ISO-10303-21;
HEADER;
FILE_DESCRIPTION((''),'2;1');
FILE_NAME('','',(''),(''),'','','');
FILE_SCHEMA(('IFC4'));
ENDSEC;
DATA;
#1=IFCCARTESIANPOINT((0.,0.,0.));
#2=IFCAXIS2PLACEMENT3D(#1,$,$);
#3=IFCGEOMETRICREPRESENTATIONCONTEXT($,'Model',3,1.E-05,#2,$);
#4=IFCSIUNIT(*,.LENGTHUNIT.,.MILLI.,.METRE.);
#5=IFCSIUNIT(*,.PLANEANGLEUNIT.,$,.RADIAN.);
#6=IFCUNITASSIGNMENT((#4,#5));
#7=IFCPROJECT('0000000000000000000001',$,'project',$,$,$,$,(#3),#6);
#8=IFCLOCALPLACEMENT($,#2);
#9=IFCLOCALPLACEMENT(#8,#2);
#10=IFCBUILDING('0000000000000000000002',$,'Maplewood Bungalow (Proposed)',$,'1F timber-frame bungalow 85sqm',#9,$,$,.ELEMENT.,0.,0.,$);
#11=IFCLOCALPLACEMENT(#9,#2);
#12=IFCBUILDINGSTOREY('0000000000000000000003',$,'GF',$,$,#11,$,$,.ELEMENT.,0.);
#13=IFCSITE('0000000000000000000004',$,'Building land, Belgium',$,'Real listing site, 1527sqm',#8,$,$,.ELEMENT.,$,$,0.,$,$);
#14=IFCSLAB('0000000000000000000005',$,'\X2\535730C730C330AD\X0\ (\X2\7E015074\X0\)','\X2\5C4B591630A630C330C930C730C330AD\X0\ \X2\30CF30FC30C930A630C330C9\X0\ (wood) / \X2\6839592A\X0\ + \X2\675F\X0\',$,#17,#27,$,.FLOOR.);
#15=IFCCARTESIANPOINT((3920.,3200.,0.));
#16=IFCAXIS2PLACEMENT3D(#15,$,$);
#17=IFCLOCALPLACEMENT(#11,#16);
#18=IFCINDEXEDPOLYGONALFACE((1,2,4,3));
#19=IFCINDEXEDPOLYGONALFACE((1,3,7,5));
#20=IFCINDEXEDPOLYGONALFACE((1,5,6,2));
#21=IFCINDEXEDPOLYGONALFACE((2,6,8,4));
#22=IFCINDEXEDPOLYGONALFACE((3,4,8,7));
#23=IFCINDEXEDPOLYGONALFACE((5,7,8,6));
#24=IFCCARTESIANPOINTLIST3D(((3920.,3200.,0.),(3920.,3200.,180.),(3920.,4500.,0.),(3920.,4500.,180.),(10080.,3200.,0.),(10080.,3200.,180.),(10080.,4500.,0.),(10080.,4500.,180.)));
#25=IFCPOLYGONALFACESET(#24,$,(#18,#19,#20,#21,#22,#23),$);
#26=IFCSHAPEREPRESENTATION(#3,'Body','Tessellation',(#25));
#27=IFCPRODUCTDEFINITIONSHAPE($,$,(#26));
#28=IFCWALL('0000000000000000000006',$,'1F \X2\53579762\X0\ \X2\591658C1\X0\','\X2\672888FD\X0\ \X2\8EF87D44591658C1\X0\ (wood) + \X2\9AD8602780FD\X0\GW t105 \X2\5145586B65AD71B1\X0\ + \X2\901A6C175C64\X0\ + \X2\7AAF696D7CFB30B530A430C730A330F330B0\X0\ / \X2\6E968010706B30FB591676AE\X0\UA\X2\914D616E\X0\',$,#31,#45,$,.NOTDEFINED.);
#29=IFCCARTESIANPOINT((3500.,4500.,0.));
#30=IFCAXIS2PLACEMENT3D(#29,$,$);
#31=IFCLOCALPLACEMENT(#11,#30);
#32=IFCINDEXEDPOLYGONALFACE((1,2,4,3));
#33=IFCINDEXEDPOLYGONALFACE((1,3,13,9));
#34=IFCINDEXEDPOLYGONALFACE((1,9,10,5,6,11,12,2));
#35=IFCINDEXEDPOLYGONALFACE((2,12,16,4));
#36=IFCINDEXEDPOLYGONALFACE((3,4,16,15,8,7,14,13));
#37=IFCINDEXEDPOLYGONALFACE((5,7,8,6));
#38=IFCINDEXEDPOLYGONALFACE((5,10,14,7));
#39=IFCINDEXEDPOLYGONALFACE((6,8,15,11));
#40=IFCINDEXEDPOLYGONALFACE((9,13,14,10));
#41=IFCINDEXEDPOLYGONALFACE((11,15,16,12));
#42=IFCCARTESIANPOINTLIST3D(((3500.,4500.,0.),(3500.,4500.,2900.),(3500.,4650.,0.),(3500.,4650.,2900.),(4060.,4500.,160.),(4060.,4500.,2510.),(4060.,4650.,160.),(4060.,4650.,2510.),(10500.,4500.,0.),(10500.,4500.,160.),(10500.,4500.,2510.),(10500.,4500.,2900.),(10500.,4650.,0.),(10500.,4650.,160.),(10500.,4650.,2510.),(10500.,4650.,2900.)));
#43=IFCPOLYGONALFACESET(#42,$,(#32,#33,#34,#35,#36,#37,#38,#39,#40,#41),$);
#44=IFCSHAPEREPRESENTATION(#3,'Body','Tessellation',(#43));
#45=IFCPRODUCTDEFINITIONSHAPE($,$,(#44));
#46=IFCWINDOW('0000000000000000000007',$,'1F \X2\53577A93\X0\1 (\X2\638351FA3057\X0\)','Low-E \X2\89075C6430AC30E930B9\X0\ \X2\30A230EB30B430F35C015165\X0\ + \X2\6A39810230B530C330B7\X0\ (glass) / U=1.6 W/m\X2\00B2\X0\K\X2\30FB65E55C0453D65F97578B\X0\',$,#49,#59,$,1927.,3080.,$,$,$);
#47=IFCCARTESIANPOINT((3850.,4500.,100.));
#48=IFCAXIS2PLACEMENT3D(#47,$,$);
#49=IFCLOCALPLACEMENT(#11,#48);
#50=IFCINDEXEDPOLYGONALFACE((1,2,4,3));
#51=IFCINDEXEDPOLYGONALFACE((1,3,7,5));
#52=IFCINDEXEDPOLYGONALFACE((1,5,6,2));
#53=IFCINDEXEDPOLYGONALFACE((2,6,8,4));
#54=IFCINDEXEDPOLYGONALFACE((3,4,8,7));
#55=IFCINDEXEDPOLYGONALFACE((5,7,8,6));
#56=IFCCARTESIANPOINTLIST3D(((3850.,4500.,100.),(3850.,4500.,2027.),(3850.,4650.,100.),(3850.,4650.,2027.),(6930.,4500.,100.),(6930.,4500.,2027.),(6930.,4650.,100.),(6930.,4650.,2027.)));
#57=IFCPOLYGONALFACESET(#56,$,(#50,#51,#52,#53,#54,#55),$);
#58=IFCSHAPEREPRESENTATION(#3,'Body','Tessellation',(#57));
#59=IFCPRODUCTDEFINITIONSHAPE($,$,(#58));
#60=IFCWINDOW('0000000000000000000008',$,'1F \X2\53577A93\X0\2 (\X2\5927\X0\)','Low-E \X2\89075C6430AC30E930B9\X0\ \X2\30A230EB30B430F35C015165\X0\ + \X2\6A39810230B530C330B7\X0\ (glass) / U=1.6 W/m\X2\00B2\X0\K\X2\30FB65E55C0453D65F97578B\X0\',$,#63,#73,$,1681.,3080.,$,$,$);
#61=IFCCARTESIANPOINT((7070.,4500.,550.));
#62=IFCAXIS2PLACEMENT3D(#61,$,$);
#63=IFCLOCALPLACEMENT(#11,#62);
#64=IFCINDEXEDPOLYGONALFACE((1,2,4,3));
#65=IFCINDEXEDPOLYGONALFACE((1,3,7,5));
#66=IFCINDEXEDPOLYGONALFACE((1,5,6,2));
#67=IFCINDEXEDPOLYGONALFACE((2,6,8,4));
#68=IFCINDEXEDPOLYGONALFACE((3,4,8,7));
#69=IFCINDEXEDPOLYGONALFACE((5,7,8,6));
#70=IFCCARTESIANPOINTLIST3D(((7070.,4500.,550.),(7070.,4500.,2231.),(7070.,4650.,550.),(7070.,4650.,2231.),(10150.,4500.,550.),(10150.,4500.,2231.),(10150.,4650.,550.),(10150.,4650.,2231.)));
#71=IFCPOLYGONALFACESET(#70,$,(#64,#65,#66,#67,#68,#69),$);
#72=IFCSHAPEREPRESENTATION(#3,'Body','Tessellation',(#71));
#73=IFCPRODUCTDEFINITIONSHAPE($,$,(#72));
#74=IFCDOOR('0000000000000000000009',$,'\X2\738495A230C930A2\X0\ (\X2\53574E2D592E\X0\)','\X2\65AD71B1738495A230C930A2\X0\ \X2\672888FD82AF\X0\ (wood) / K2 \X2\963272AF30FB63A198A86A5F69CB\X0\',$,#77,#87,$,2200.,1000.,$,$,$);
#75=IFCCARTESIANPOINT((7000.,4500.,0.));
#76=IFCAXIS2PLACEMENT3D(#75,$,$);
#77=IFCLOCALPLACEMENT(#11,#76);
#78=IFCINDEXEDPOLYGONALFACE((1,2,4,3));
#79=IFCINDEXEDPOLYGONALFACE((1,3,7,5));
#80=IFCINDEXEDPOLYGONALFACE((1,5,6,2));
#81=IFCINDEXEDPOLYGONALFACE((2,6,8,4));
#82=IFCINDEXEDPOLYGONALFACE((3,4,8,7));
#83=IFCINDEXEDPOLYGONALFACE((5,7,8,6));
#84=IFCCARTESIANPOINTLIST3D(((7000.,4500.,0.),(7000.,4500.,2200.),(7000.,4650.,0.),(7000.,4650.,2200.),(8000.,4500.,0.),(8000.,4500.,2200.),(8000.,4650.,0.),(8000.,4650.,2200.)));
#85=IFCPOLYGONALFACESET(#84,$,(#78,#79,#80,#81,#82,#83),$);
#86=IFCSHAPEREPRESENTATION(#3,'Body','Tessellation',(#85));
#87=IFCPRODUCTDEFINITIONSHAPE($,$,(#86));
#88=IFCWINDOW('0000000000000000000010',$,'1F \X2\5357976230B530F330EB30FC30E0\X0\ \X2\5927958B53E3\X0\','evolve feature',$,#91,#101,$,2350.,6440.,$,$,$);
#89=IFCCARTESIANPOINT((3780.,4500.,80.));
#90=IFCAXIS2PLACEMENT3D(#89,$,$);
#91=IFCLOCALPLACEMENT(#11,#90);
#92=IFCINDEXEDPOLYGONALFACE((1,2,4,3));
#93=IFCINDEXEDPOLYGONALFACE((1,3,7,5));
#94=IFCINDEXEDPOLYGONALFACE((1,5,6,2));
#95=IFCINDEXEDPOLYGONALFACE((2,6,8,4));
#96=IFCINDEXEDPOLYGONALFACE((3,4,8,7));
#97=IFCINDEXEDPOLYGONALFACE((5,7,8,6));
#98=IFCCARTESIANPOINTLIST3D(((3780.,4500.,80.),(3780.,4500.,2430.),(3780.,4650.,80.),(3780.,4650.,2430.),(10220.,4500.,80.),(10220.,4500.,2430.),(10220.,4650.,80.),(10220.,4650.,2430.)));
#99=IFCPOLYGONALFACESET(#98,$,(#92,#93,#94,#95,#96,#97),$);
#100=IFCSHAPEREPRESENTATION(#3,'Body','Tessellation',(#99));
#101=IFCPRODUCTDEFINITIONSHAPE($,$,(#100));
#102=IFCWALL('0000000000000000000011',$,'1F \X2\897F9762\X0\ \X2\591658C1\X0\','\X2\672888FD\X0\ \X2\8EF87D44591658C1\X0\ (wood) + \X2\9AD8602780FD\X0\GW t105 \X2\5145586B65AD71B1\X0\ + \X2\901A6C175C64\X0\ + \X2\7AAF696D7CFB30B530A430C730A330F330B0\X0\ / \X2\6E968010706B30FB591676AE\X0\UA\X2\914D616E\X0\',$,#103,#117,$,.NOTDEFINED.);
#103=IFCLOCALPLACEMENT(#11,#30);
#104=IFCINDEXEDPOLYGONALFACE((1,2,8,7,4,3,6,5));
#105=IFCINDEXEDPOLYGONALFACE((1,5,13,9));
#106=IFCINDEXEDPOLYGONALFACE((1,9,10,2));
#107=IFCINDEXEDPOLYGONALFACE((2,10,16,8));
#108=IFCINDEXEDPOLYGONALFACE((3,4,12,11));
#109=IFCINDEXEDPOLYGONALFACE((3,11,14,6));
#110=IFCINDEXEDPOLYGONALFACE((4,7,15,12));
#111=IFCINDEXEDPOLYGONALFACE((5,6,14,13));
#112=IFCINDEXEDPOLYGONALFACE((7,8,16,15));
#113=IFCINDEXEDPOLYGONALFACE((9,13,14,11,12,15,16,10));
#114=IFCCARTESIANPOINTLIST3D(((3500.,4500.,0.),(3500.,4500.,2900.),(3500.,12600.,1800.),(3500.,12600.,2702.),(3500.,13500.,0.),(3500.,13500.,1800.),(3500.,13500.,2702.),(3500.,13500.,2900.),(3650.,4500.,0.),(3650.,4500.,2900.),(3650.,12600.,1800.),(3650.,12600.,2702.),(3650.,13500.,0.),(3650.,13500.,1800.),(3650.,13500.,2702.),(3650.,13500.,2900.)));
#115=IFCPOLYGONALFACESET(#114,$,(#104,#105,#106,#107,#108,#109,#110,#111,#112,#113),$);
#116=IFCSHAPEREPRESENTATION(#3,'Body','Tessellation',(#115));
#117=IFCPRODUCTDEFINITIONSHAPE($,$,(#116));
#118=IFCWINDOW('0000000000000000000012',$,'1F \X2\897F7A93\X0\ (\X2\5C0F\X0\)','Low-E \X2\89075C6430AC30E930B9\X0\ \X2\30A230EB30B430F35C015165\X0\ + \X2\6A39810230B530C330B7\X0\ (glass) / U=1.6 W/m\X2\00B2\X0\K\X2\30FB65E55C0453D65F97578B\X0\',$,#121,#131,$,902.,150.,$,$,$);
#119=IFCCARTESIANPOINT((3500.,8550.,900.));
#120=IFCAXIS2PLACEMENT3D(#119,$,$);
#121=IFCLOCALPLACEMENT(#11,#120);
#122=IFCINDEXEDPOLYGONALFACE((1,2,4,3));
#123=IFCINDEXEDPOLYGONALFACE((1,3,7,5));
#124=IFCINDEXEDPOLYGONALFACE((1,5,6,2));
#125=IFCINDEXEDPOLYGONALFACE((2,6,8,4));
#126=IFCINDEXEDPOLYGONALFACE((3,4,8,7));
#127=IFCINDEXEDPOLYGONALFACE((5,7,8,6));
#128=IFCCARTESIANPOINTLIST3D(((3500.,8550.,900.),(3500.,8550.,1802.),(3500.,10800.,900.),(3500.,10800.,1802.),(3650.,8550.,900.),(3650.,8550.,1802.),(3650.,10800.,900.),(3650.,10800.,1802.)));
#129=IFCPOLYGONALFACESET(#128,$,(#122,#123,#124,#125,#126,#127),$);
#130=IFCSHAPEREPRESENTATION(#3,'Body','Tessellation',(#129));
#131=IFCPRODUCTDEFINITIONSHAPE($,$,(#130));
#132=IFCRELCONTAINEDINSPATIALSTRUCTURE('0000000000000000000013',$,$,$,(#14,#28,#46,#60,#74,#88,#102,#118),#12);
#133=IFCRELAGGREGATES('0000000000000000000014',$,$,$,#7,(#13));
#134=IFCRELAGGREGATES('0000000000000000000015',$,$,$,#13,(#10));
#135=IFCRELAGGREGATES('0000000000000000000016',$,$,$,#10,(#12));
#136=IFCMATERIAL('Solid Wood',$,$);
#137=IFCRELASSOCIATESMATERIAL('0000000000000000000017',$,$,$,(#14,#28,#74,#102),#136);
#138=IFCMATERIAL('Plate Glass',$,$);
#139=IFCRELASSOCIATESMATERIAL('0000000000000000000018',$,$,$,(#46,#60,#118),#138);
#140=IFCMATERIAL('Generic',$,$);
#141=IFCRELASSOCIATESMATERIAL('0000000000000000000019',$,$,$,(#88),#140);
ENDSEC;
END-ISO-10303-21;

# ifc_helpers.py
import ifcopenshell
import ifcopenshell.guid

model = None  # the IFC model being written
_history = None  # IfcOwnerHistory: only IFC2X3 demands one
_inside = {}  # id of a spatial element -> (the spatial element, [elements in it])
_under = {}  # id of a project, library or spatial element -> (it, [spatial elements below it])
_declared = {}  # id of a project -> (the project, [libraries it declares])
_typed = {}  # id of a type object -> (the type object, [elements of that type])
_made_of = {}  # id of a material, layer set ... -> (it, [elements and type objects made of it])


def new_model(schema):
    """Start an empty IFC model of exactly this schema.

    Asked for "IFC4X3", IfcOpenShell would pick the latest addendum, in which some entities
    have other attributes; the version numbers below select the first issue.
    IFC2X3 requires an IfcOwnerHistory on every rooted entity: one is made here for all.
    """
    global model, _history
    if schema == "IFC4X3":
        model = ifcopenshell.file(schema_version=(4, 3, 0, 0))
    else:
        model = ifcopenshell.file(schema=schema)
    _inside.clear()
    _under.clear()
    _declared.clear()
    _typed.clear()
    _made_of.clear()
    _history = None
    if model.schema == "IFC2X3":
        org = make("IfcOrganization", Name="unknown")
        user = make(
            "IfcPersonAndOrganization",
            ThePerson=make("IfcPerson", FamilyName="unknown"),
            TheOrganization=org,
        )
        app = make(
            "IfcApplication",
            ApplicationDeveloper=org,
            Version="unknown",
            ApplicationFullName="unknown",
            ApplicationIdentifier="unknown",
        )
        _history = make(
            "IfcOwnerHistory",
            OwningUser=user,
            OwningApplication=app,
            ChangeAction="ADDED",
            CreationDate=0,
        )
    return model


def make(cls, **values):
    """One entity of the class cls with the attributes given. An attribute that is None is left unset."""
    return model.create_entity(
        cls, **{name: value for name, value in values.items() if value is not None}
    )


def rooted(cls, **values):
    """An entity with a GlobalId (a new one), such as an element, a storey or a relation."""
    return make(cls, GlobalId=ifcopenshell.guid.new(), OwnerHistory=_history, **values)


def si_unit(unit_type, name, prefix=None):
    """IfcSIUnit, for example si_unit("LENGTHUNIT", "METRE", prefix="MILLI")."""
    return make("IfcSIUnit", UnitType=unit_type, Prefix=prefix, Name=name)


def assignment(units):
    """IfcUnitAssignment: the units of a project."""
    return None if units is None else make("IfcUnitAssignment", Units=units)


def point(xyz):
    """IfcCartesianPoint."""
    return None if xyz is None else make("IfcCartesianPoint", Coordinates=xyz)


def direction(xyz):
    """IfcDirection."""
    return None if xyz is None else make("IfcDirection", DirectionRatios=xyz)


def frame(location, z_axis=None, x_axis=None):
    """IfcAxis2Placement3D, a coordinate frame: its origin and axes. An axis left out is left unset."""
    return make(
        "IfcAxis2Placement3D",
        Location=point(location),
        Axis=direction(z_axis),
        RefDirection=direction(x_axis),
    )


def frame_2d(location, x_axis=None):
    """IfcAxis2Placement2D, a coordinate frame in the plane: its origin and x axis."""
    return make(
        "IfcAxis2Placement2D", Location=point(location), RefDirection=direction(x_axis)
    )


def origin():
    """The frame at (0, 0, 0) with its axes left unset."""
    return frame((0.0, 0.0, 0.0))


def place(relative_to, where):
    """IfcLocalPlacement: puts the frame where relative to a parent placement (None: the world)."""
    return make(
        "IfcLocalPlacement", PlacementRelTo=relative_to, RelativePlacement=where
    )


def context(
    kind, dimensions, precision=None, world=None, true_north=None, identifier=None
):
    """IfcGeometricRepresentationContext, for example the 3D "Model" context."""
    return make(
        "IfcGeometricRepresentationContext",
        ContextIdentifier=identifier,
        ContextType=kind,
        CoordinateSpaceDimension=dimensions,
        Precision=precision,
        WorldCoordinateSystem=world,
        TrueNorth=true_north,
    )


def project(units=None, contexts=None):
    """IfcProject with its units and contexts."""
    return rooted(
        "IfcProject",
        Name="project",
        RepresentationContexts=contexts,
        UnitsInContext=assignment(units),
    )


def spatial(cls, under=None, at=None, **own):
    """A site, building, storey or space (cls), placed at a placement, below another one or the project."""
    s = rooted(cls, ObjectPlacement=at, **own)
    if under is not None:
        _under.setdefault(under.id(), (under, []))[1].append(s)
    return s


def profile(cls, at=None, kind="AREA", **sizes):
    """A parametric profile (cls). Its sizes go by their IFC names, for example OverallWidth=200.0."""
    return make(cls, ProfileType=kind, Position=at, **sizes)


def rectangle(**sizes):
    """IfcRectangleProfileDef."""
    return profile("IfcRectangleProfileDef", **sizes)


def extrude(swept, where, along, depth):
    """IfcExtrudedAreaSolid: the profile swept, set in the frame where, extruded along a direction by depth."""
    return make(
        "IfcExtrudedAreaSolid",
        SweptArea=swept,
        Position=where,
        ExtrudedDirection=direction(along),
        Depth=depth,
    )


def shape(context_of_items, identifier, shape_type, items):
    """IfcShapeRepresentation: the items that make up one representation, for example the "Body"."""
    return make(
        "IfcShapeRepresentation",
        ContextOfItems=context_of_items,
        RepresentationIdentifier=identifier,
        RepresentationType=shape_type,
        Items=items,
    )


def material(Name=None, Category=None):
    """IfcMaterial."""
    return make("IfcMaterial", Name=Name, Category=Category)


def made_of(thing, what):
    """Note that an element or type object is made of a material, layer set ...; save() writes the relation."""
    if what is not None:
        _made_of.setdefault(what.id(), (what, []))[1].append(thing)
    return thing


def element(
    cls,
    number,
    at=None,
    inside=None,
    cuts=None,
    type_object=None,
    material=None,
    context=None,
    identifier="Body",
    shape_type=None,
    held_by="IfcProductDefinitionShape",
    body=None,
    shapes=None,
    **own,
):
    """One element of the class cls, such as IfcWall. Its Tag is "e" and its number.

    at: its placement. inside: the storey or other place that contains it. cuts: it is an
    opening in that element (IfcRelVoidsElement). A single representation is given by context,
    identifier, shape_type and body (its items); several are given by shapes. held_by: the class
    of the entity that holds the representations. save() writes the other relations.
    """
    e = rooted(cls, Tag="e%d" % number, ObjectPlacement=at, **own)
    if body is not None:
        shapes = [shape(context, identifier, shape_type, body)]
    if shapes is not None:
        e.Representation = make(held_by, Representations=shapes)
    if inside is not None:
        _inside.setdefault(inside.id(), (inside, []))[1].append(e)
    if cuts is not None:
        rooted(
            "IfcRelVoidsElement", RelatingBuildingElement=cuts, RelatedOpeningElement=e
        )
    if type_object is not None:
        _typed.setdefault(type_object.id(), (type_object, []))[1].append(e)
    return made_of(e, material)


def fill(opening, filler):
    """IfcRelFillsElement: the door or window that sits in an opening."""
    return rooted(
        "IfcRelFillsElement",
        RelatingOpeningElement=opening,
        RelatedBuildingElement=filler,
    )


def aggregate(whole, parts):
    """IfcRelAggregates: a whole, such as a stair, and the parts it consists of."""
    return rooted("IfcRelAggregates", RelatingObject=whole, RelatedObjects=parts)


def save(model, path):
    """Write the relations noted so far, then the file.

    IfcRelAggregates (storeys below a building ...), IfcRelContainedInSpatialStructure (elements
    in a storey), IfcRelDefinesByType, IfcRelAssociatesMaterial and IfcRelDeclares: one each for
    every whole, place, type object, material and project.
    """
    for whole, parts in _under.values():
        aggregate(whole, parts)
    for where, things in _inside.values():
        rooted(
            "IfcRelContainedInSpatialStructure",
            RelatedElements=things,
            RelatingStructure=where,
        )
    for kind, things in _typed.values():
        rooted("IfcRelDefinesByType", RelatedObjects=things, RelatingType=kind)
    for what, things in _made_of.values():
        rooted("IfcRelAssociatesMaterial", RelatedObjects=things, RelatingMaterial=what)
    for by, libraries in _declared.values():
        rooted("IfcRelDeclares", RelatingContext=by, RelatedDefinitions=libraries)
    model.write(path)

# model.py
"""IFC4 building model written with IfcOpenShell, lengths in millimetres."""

from ifc_helpers import new_model, si_unit, frame, frame_2d, origin, place, context, project, spatial, rectangle, extrude, material, element, fill, save


model = new_model("IFC4")

# Units and contexts
model_context = context("Model", 3, precision=1e-05, world=origin())
ifc_project = project(units=[si_unit("LENGTHUNIT", "METRE", prefix="MILLI"), si_unit("PLANEANGLEUNIT", "RADIAN")], contexts=[model_context])

# Site, building, storey
site_placement = place(None, origin())
site = spatial("IfcSite", under=ifc_project, at=site_placement, Name="Building land, Belgium", ObjectType="Real listing site, 1527sqm", CompositionType="ELEMENT", RefElevation=0.0)
building_placement = place(site_placement, origin())
building = spatial("IfcBuilding", under=site, at=building_placement, Name="Maplewood Bungalow (Proposed)", ObjectType="1F timber-frame bungalow 85sqm", CompositionType="ELEMENT", ElevationOfRefHeight=0.0, ElevationOfTerrain=0.0)
storey_placement = place(building_placement, origin())
storey = spatial("IfcBuildingStorey", under=building, at=storey_placement, Name="GF", CompositionType="ELEMENT", Elevation=0.0)

# Slab
ifc_material_1 = material(Name="Solid Wood")
slab_1_placement = place(storey_placement, frame((3920.0, 3200.0, 0.0)))
element("IfcSlab", 1, at=slab_1_placement, inside=storey, material=ifc_material_1, Name="南デッキ (縁側)", Description="屋外ウッドデッキ ハードウッド (wood) / 根太 + 束", PredefinedType="FLOOR", context=model_context, shape_type="SweptSolid", body=[
    extrude(rectangle(XDim=6160.0, YDim=1300.0, at=frame_2d((3080.0, 650.0))), frame((3920.0, 3200.0, 0.0)), (0.0, 0.0, 1.0), 180.0),
])
ifc_material_2 = material(Name="Generic")

# Wall, openings, windows, door
wall_1_placement = place(storey_placement, frame((3500.0, 4500.0, 0.0)))
wall_1 = element("IfcWall", 2, at=wall_1_placement, inside=storey, material=ifc_material_1, Name="1F 南面 外壁", Description="木製 軸組外壁 (wood) + 高性能GW t105 充填断熱 + 通気層 + 窯業系サイディング / 準耐火・外皮UA配慮", PredefinedType="NOTDEFINED", context=model_context, shape_type="SweptSolid", body=[
    extrude(rectangle(XDim=7000.0, YDim=150.0, at=frame_2d((3500.0, 75.0))), frame((3500.0, 4500.0, 0.0)), (0.0, 0.0, 1.0), 2900.0),
])
opening_1_placement = place(storey_placement, frame((3850.0, 4500.0, 100.0)))
opening_1 = element("IfcOpeningElement", 3, at=opening_1_placement, cuts=wall_1, PredefinedType="NOTDEFINED", context=model_context, shape_type="SweptSolid", body=[
    extrude(rectangle(XDim=3080.0, YDim=150.0, at=frame_2d((1540.0, 75.0))), frame((3850.0, 4500.0, 100.0)), (0.0, 0.0, 1.0), 1927.0),
])
opening_2_placement = place(storey_placement, frame((7070.0, 4500.0, 550.0)))
opening_2 = element("IfcOpeningElement", 4, at=opening_2_placement, cuts=wall_1, PredefinedType="NOTDEFINED", context=model_context, shape_type="SweptSolid", body=[
    extrude(rectangle(XDim=3080.0, YDim=150.0, at=frame_2d((1540.0, 75.0))), frame((7070.0, 4500.0, 550.0)), (0.0, 0.0, 1.0), 1681.0),
])
opening_3_placement = place(storey_placement, frame((7000.0, 4500.0, 0.0)))
opening_3 = element("IfcOpeningElement", 5, at=opening_3_placement, cuts=wall_1, PredefinedType="NOTDEFINED", context=model_context, shape_type="SweptSolid", body=[
    extrude(rectangle(XDim=1000.0, YDim=150.0, at=frame_2d((500.0, 75.0))), frame((7000.0, 4500.0, 0.0)), (0.0, 0.0, 1.0), 2200.0),
])
opening_4_placement = place(storey_placement, frame((3780.0, 4500.0, 80.0)))
opening_4 = element("IfcOpeningElement", 6, at=opening_4_placement, cuts=wall_1, PredefinedType="NOTDEFINED", context=model_context, shape_type="SweptSolid", body=[
    extrude(rectangle(XDim=6440.0, YDim=150.0, at=frame_2d((3220.0, 75.0))), frame((3780.0, 4500.0, 80.0)), (0.0, 0.0, 1.0), 2350.0),
])
ifc_material_3 = material(Name="Plate Glass")
window_1_placement = place(storey_placement, frame((3850.0, 4500.0, 100.0)))
window_1 = element("IfcWindow", 7, at=window_1_placement, inside=storey, material=ifc_material_3, Name="1F 南窓1 (掃出し)", Description="Low-E 複層ガラス アルゴン封入 + 樹脂サッシ (glass) / U=1.6 W/m²K・日射取得型", OverallHeight=1927.0, OverallWidth=3080.0, context=model_context, shape_type="SweptSolid", body=[
    extrude(rectangle(XDim=3080.0, YDim=150.0, at=frame_2d((1540.0, 75.0))), frame((3850.0, 4500.0, 100.0)), (0.0, 0.0, 1.0), 1927.0),
])
fill(opening_1, window_1)
window_2_placement = place(storey_placement, frame((7070.0, 4500.0, 550.0)))
window_2 = element("IfcWindow", 8, at=window_2_placement, inside=storey, material=ifc_material_3, Name="1F 南窓2 (大)", Description="Low-E 複層ガラス アルゴン封入 + 樹脂サッシ (glass) / U=1.6 W/m²K・日射取得型", OverallHeight=1681.0, OverallWidth=3080.0, context=model_context, shape_type="SweptSolid", body=[
    extrude(rectangle(XDim=3080.0, YDim=150.0, at=frame_2d((1540.0, 75.0))), frame((7070.0, 4500.0, 550.0)), (0.0, 0.0, 1.0), 1681.0),
])
fill(opening_2, window_2)
door_placement = place(storey_placement, frame((7000.0, 4500.0, 0.0)))
door = element("IfcDoor", 9, at=door_placement, inside=storey, material=ifc_material_1, Name="玄関ドア (南中央)", Description="断熱玄関ドア 木製芯 (wood) / K2 防犯・採風機構", OverallHeight=2200.0, OverallWidth=1000.0, context=model_context, shape_type="SweptSolid", body=[
    extrude(rectangle(XDim=1000.0, YDim=150.0, at=frame_2d((500.0, 75.0))), frame((7000.0, 4500.0, 0.0)), (0.0, 0.0, 1.0), 2200.0),
])
fill(opening_3, door)
window_3_placement = place(storey_placement, frame((3780.0, 4500.0, 80.0)))
window_3 = element("IfcWindow", 10, at=window_3_placement, inside=storey, material=ifc_material_2, Name="1F 南面サンルーム 大開口", Description="evolve feature", OverallHeight=2350.0, OverallWidth=6440.0, context=model_context, shape_type="SweptSolid", body=[
    extrude(rectangle(XDim=6440.0, YDim=150.0, at=frame_2d((3220.0, 75.0))), frame((3780.0, 4500.0, 80.0)), (0.0, 0.0, 1.0), 2350.0),
])
fill(opening_4, window_3)

# Wall, opening, window
wall_2_placement = place(storey_placement, frame((3500.0, 4500.0, 0.0)))
wall_2 = element("IfcWall", 11, at=wall_2_placement, inside=storey, material=ifc_material_1, Name="1F 西面 外壁", Description="木製 軸組外壁 (wood) + 高性能GW t105 充填断熱 + 通気層 + 窯業系サイディング / 準耐火・外皮UA配慮", PredefinedType="NOTDEFINED", context=model_context, shape_type="SweptSolid", body=[
    extrude(rectangle(XDim=150.0, YDim=9000.0, at=frame_2d((75.0, 4500.0))), frame((3500.0, 4500.0, 0.0)), (0.0, 0.0, 1.0), 2900.0),
])
opening_5_placement = place(storey_placement, frame((3500.0, 8550.0, 900.0)))
opening_5 = element("IfcOpeningElement", 12, at=opening_5_placement, cuts=wall_2, PredefinedType="NOTDEFINED", context=model_context, shape_type="SweptSolid", body=[
    extrude(rectangle(XDim=150.0, YDim=2250.0, at=frame_2d((75.0, 1125.0))), frame((3500.0, 8550.0, 900.0)), (0.0, 0.0, 1.0), 902.0),
])
window_4_placement = place(storey_placement, frame((3500.0, 8550.0, 900.0)))
window_4 = element("IfcWindow", 13, at=window_4_placement, inside=storey, material=ifc_material_3, Name="1F 西窓 (小)", Description="Low-E 複層ガラス アルゴン封入 + 樹脂サッシ (glass) / U=1.6 W/m²K・日射取得型", OverallHeight=902.0, OverallWidth=150.0, context=model_context, shape_type="SweptSolid", body=[
    extrude(rectangle(XDim=150.0, YDim=2250.0, at=frame_2d((75.0, 1125.0))), frame((3500.0, 8550.0, 900.0)), (0.0, 0.0, 1.0), 902.0),
])
fill(opening_5, window_4)

save(model, "model.ifc")
